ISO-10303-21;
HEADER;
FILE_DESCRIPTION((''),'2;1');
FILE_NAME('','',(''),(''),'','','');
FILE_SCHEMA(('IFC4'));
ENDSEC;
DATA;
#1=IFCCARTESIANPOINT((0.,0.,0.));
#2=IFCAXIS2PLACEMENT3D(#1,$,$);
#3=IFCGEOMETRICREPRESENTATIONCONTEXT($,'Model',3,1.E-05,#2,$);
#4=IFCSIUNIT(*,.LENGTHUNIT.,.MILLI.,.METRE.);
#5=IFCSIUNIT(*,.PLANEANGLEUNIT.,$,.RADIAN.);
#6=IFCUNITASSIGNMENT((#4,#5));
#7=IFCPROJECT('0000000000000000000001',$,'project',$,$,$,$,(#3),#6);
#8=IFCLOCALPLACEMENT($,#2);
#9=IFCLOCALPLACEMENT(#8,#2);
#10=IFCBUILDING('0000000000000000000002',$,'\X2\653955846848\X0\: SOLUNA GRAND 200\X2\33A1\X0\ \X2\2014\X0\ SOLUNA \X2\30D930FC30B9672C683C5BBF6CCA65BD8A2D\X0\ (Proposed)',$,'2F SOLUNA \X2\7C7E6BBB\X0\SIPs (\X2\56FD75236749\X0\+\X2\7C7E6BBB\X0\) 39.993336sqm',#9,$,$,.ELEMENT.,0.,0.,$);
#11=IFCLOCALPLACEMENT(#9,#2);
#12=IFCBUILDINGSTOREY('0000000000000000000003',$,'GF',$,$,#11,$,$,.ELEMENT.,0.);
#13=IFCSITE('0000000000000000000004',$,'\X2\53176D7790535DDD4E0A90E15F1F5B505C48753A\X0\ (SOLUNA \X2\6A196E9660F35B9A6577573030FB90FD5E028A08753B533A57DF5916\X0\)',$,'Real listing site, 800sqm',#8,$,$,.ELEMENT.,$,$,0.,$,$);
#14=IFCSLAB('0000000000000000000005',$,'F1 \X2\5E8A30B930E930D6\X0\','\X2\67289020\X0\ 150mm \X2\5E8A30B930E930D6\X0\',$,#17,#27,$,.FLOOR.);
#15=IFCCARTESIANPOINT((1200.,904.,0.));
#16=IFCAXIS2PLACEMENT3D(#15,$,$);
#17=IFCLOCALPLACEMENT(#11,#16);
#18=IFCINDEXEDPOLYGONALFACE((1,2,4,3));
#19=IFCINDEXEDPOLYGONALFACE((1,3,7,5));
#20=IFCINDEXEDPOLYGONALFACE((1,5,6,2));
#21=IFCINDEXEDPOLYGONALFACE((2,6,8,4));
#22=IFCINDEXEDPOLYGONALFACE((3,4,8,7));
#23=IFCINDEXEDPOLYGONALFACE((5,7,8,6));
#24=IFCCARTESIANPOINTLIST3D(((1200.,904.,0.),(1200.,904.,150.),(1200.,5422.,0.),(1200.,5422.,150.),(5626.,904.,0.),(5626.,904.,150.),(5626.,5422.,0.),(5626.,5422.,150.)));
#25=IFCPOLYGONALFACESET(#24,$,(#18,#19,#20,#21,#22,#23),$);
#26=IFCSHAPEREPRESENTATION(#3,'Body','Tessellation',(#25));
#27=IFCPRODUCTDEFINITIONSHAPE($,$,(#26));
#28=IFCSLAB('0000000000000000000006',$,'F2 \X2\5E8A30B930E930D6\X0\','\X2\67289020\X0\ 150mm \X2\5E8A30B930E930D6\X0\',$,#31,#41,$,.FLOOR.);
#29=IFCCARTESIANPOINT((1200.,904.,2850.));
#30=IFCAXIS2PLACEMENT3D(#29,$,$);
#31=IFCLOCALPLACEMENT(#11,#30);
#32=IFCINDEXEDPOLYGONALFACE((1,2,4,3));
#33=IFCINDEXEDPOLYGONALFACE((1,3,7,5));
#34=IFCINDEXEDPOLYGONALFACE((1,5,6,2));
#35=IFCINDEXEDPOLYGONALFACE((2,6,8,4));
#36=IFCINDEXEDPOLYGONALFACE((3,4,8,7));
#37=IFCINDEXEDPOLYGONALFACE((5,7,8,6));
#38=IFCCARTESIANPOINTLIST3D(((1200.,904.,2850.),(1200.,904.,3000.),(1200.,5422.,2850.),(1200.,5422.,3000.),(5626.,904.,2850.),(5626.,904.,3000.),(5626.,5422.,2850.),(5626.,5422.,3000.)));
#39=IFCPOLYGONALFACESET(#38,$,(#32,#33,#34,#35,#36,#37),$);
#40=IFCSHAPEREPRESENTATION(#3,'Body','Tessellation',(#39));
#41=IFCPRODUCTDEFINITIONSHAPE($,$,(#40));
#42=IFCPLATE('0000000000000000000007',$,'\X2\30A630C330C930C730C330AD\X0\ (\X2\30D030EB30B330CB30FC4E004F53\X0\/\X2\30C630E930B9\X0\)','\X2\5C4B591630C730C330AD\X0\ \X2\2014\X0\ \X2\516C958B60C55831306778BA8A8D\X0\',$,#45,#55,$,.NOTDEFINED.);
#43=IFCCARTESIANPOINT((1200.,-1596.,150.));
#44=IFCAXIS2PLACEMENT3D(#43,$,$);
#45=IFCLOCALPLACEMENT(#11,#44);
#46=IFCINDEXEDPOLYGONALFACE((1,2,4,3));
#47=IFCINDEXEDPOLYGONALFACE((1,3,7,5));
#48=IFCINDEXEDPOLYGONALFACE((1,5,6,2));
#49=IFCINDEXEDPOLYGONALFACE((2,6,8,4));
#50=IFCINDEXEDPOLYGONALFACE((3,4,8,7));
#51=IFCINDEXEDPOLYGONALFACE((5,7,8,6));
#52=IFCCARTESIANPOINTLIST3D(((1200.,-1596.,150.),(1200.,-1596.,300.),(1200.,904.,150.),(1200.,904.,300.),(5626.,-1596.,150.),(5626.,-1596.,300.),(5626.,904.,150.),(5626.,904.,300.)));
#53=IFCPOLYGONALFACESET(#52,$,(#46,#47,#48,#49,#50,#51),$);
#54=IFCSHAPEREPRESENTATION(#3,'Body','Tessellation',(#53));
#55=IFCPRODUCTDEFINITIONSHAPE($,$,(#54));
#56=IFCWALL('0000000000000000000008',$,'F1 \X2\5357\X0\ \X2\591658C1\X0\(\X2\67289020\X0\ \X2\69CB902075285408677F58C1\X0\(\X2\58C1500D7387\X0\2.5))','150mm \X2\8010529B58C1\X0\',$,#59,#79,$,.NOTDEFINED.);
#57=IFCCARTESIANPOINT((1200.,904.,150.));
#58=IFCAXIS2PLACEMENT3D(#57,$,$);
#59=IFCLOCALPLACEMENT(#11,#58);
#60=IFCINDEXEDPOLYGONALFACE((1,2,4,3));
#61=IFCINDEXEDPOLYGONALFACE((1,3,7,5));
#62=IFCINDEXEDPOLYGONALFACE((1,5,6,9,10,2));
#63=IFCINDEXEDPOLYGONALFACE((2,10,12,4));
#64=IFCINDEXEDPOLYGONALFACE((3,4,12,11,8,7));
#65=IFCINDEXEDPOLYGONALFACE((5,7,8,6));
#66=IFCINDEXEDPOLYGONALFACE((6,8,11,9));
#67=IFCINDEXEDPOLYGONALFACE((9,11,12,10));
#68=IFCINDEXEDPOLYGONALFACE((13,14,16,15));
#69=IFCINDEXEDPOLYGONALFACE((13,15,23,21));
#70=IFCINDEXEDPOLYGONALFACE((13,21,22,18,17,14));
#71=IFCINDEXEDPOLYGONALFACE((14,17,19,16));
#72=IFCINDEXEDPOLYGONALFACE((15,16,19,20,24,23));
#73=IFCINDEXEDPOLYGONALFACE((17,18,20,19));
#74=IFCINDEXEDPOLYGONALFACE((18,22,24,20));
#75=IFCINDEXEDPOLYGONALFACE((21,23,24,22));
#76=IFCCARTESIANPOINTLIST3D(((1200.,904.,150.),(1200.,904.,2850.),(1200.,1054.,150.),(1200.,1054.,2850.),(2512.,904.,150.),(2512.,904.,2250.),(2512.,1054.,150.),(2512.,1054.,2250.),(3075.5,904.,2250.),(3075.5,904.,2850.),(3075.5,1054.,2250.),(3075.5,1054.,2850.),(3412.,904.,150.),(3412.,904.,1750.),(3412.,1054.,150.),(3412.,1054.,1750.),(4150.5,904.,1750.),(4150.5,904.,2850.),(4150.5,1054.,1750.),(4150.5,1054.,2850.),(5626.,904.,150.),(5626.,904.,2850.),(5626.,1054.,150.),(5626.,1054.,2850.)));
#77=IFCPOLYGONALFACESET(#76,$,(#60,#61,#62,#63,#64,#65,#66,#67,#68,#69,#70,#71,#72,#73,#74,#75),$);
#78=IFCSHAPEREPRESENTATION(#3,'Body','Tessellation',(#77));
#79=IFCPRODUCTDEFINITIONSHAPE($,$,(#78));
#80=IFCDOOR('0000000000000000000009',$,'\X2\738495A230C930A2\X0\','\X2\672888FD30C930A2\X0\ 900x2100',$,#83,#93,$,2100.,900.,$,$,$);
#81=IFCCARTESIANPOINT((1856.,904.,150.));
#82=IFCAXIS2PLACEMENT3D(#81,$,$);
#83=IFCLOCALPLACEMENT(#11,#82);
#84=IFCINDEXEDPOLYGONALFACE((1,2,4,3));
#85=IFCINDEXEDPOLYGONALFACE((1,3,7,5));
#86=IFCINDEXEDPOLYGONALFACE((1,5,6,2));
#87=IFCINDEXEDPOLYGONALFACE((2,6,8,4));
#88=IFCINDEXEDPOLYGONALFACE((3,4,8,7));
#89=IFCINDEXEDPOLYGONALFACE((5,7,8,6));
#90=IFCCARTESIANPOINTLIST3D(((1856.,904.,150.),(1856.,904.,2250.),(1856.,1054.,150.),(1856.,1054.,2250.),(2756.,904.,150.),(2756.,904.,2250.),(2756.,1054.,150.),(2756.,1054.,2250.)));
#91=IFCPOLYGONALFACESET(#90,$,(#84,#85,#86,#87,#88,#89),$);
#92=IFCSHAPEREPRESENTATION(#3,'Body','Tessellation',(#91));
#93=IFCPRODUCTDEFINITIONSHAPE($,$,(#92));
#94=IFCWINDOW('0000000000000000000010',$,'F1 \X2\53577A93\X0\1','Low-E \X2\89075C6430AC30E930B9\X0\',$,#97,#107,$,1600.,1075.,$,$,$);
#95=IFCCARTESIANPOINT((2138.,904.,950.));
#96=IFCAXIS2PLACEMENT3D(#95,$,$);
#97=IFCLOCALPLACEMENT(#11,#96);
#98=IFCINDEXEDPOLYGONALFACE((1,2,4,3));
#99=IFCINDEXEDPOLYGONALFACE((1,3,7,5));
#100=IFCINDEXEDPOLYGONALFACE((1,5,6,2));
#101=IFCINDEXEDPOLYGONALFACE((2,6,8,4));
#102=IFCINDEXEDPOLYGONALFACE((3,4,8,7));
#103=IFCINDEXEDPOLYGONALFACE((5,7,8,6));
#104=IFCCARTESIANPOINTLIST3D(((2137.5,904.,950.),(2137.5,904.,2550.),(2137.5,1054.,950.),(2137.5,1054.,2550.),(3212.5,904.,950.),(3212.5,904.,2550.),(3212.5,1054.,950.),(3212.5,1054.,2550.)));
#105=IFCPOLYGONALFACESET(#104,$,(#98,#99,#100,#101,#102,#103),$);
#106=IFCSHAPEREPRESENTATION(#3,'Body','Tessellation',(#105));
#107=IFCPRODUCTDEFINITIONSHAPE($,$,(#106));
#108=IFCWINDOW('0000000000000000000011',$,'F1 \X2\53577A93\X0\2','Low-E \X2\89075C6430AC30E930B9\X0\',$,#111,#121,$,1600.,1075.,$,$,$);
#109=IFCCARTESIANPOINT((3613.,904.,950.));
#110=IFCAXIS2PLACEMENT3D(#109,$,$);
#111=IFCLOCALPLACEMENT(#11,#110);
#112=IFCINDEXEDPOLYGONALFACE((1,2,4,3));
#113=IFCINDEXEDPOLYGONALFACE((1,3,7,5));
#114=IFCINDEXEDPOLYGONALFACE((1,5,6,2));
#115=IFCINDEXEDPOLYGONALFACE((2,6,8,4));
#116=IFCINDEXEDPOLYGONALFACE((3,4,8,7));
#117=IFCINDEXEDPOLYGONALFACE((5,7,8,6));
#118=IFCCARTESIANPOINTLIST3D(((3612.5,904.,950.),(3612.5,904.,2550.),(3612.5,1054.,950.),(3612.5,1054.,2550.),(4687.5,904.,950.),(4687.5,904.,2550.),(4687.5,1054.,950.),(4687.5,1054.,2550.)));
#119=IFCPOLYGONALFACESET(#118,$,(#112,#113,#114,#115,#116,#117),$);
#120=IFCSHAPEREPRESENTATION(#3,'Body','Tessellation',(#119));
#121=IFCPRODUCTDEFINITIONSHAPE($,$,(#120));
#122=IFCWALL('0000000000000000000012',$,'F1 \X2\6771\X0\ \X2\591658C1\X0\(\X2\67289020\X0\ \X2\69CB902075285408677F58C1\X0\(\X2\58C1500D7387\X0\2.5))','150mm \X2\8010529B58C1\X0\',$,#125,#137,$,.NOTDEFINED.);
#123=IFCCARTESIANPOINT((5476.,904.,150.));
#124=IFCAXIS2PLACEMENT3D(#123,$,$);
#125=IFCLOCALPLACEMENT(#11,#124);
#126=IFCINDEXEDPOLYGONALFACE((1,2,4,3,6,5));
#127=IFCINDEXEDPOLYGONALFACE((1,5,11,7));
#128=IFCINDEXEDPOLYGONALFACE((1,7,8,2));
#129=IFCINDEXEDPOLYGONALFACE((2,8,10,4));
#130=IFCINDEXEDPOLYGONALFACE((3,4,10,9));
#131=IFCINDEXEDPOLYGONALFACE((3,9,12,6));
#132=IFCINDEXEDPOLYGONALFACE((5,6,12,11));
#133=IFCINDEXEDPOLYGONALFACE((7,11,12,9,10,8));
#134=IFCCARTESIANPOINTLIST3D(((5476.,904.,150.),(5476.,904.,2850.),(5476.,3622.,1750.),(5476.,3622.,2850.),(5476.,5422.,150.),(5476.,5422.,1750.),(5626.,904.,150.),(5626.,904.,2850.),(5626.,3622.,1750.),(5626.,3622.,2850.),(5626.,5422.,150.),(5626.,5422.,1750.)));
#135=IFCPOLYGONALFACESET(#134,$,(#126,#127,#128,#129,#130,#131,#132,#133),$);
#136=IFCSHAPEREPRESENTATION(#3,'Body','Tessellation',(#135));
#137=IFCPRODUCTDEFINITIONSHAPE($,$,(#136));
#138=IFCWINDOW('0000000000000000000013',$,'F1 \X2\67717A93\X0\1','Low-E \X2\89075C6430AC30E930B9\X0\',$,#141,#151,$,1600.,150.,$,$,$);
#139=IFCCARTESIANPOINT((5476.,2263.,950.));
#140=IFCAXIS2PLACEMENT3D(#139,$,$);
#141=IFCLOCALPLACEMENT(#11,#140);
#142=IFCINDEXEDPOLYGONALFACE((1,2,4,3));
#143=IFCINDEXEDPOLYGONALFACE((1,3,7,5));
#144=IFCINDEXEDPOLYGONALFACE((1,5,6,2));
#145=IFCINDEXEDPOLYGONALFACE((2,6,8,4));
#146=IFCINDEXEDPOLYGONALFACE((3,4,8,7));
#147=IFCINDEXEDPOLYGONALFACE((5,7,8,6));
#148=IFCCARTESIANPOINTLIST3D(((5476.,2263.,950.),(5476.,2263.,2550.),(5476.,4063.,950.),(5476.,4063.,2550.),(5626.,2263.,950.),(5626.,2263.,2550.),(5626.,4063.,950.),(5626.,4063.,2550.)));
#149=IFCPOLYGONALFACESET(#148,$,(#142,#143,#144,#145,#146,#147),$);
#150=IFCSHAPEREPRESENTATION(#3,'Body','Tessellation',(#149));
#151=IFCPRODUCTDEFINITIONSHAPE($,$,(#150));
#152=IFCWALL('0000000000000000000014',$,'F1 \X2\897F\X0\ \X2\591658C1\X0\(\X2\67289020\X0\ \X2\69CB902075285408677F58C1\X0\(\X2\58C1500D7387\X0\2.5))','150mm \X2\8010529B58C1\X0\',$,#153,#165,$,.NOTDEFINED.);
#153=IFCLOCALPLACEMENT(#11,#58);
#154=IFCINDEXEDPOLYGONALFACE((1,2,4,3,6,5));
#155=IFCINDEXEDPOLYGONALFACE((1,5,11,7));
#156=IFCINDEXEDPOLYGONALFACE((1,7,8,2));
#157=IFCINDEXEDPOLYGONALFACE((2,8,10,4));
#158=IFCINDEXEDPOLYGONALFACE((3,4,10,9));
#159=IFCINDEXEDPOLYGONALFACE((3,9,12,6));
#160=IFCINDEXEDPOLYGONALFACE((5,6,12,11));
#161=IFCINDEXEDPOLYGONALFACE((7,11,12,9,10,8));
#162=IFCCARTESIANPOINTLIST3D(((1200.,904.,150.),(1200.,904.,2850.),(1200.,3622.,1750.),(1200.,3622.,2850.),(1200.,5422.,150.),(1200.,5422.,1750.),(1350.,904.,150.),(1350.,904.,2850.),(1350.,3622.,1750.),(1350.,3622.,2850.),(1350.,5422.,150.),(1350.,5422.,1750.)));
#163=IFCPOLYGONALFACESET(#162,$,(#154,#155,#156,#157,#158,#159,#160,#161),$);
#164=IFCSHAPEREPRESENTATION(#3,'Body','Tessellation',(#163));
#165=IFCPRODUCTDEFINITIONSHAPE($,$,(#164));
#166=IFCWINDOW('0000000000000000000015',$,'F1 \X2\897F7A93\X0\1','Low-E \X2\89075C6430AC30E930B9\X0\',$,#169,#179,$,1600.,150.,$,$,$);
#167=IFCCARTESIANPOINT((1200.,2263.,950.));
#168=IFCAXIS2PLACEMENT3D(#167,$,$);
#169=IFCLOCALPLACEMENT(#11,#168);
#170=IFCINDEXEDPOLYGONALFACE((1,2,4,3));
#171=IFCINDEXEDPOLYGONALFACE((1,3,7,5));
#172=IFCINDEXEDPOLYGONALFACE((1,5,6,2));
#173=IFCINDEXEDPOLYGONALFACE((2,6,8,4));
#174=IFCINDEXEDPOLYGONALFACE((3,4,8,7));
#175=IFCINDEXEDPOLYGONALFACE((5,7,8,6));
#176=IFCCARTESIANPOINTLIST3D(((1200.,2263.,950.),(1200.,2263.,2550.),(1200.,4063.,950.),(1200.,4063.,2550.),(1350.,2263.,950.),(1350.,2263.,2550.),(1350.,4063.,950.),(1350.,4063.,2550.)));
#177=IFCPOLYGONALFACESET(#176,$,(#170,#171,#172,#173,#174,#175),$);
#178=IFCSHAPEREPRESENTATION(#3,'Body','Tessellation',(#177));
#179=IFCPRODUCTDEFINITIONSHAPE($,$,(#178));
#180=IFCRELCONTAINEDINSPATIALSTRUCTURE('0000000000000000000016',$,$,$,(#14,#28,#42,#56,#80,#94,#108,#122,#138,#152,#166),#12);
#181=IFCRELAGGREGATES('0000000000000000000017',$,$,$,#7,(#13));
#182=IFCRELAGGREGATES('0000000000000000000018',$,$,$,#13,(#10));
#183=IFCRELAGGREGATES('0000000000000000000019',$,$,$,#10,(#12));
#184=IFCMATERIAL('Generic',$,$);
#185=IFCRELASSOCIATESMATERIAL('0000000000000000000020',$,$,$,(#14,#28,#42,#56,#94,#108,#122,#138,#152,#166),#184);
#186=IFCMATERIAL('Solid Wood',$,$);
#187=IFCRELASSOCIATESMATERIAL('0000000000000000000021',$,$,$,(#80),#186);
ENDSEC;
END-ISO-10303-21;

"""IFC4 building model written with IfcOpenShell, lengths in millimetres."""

from ifc_helpers import new_model, si_unit, frame, frame_2d, origin, place, context, project, spatial, rectangle, extrude, material, element, fill, save


model = new_model("IFC4")

# Units and contexts
model_context = context("Model", 3, precision=1e-05, world=origin())
ifc_project = project(units=[si_unit("LENGTHUNIT", "METRE", prefix="MILLI"), si_unit("PLANEANGLEUNIT", "RADIAN")], contexts=[model_context])

# Site, building, storey
site_placement = place(None, origin())
site = spatial("IfcSite", under=ifc_project, at=site_placement, Name="北海道川上郡弟子屈町 (SOLUNA 標準想定敷地・都市計画区域外)", ObjectType="Real listing site, 800sqm", CompositionType="ELEMENT", RefElevation=0.0)
building_placement = place(site_placement, origin())
building = spatial("IfcBuilding", under=site, at=building_placement, Name="改善案: SOLUNA GRAND 200㎡ — SOLUNA ベース本格宿泊施設 (Proposed)", ObjectType="2F SOLUNA 籾殻SIPs (国産杉+籾殻) 39.993336sqm", CompositionType="ELEMENT", ElevationOfRefHeight=0.0, ElevationOfTerrain=0.0)
storey_placement = place(building_placement, origin())
storey = spatial("IfcBuildingStorey", under=building, at=storey_placement, Name="GF", CompositionType="ELEMENT", Elevation=0.0)

# Slabs
ifc_material_1 = material(Name="Generic")
slab_1_placement = place(storey_placement, frame((1200.0, 904.0, 0.0)))
element("IfcSlab", 1, at=slab_1_placement, inside=storey, material=ifc_material_1, Name="F1 床スラブ", Description="木造 150mm 床スラブ", PredefinedType="FLOOR", context=model_context, shape_type="SweptSolid", body=[
    extrude(rectangle(XDim=4426.0, YDim=4518.0, at=frame_2d((2213.0, 2259.0))), frame((1200.0, 904.0, 0.0)), (0.0, 0.0, 1.0), 150.0),
])
slab_2_placement = place(storey_placement, frame((1200.0, 904.0, 2850.0)))
element("IfcSlab", 2, at=slab_2_placement, inside=storey, material=ifc_material_1, Name="F2 床スラブ", Description="木造 150mm 床スラブ", PredefinedType="FLOOR", context=model_context, shape_type="SweptSolid", body=[
    extrude(rectangle(XDim=4426.0, YDim=4518.0, at=frame_2d((2213.0, 2259.0))), frame((1200.0, 904.0, 2850.0)), (0.0, 0.0, 1.0), 150.0),
])

# Plate
plate_placement = place(storey_placement, frame((1200.0, -1596.0, 150.0)))
element("IfcPlate", 3, at=plate_placement, inside=storey, material=ifc_material_1, Name="ウッドデッキ (バルコニー一体/テラス)", Description="屋外デッキ — 公開情報で確認", PredefinedType="NOTDEFINED", context=model_context, shape_type="SweptSolid", body=[
    extrude(rectangle(XDim=4426.0, YDim=2500.0, at=frame_2d((2213.0, 1250.0))), frame((1200.0, -1596.0, 150.0)), (0.0, 0.0, 1.0), 150.0),
])

# Wall, openings, door, windows
wall_1_placement = place(storey_placement, frame((1200.0, 904.0, 150.0)))
wall_1 = element("IfcWall", 4, at=wall_1_placement, inside=storey, material=ifc_material_1, Name="F1 南 外壁(木造 構造用合板壁(壁倍率2.5))", Description="150mm 耐力壁", PredefinedType="NOTDEFINED", context=model_context, shape_type="SweptSolid", body=[
    extrude(rectangle(XDim=4426.0, YDim=150.0, at=frame_2d((2213.0, 75.0))), frame((1200.0, 904.0, 150.0)), (0.0, 0.0, 1.0), 2700.0),
])
opening_1_placement = place(storey_placement, frame((1856.0, 904.0, 150.0)))
opening_1 = element("IfcOpeningElement", 5, at=opening_1_placement, cuts=wall_1, PredefinedType="NOTDEFINED", context=model_context, shape_type="SweptSolid", body=[
    extrude(rectangle(XDim=900.0, YDim=150.0, at=frame_2d((450.0, 75.0))), frame((1856.0, 904.0, 150.0)), (0.0, 0.0, 1.0), 2100.0),
])
opening_2_placement = place(storey_placement, frame((2138.0, 904.0, 950.0)))
opening_2 = element("IfcOpeningElement", 6, at=opening_2_placement, cuts=wall_1, PredefinedType="NOTDEFINED", context=model_context, shape_type="SweptSolid", body=[
    extrude(rectangle(XDim=1075.0, YDim=150.0, at=frame_2d((537.0, 75.0))), frame((2138.0, 904.0, 950.0)), (0.0, 0.0, 1.0), 1600.0),
])
opening_3_placement = place(storey_placement, frame((3613.0, 904.0, 950.0)))
opening_3 = element("IfcOpeningElement", 7, at=opening_3_placement, cuts=wall_1, PredefinedType="NOTDEFINED", context=model_context, shape_type="SweptSolid", body=[
    extrude(rectangle(XDim=1075.0, YDim=150.0, at=frame_2d((537.0, 75.0))), frame((3613.0, 904.0, 950.0)), (0.0, 0.0, 1.0), 1600.0),
])
ifc_material_2 = material(Name="Solid Wood")
door_placement = place(storey_placement, frame((1856.0, 904.0, 150.0)))
door = element("IfcDoor", 8, at=door_placement, inside=storey, material=ifc_material_2, Name="玄関ドア", Description="木製ドア 900x2100", OverallHeight=2100.0, OverallWidth=900.0, context=model_context, shape_type="SweptSolid", body=[
    extrude(rectangle(XDim=900.0, YDim=150.0, at=frame_2d((450.0, 75.0))), frame((1856.0, 904.0, 150.0)), (0.0, 0.0, 1.0), 2100.0),
])
fill(opening_1, door)
window_1_placement = place(storey_placement, frame((2138.0, 904.0, 950.0)))
window_1 = element("IfcWindow", 9, at=window_1_placement, inside=storey, material=ifc_material_1, Name="F1 南窓1", Description="Low-E 複層ガラス", OverallHeight=1600.0, OverallWidth=1075.0, context=model_context, shape_type="SweptSolid", body=[
    extrude(rectangle(XDim=1075.0, YDim=150.0, at=frame_2d((537.0, 75.0))), frame((2138.0, 904.0, 950.0)), (0.0, 0.0, 1.0), 1600.0),
])
fill(opening_2, window_1)
window_2_placement = place(storey_placement, frame((3613.0, 904.0, 950.0)))
window_2 = element("IfcWindow", 10, at=window_2_placement, inside=storey, material=ifc_material_1, Name="F1 南窓2", Description="Low-E 複層ガラス", OverallHeight=1600.0, OverallWidth=1075.0, context=model_context, shape_type="SweptSolid", body=[
    extrude(rectangle(XDim=1075.0, YDim=150.0, at=frame_2d((537.0, 75.0))), frame((3613.0, 904.0, 950.0)), (0.0, 0.0, 1.0), 1600.0),
])
fill(opening_3, window_2)

# Walls, openings, windows
wall_2_placement = place(storey_placement, frame((5476.0, 904.0, 150.0)))
wall_2 = element("IfcWall", 11, at=wall_2_placement, inside=storey, material=ifc_material_1, Name="F1 東 外壁(木造 構造用合板壁(壁倍率2.5))", Description="150mm 耐力壁", PredefinedType="NOTDEFINED", context=model_context, shape_type="SweptSolid", body=[
    extrude(rectangle(XDim=150.0, YDim=4518.0, at=frame_2d((75.0, 2259.0))), frame((5476.0, 904.0, 150.0)), (0.0, 0.0, 1.0), 2700.0),
])
opening_4_placement = place(storey_placement, frame((5476.0, 2263.0, 950.0)))
opening_4 = element("IfcOpeningElement", 12, at=opening_4_placement, cuts=wall_2, PredefinedType="NOTDEFINED", context=model_context, shape_type="SweptSolid", body=[
    extrude(rectangle(XDim=150.0, YDim=1800.0, at=frame_2d((75.0, 900.0))), frame((5476.0, 2263.0, 950.0)), (0.0, 0.0, 1.0), 1600.0),
])
window_3_placement = place(storey_placement, frame((5476.0, 2263.0, 950.0)))
window_3 = element("IfcWindow", 13, at=window_3_placement, inside=storey, material=ifc_material_1, Name="F1 東窓1", Description="Low-E 複層ガラス", OverallHeight=1600.0, OverallWidth=150.0, context=model_context, shape_type="SweptSolid", body=[
    extrude(rectangle(XDim=150.0, YDim=1800.0, at=frame_2d((75.0, 900.0))), frame((5476.0, 2263.0, 950.0)), (0.0, 0.0, 1.0), 1600.0),
])
fill(opening_4, window_3)
wall_3_placement = place(storey_placement, frame((1200.0, 904.0, 150.0)))
wall_3 = element("IfcWall", 14, at=wall_3_placement, inside=storey, material=ifc_material_1, Name="F1 西 外壁(木造 構造用合板壁(壁倍率2.5))", Description="150mm 耐力壁", PredefinedType="NOTDEFINED", context=model_context, shape_type="SweptSolid", body=[
    extrude(rectangle(XDim=150.0, YDim=4518.0, at=frame_2d((75.0, 2259.0))), frame((1200.0, 904.0, 150.0)), (0.0, 0.0, 1.0), 2700.0),
])
opening_5_placement = place(storey_placement, frame((1200.0, 2263.0, 950.0)))
opening_5 = element("IfcOpeningElement", 15, at=opening_5_placement, cuts=wall_3, PredefinedType="NOTDEFINED", context=model_context, shape_type="SweptSolid", body=[
    extrude(rectangle(XDim=150.0, YDim=1800.0, at=frame_2d((75.0, 900.0))), frame((1200.0, 2263.0, 950.0)), (0.0, 0.0, 1.0), 1600.0),
])
window_4_placement = place(storey_placement, frame((1200.0, 2263.0, 950.0)))
window_4 = element("IfcWindow", 16, at=window_4_placement, inside=storey, material=ifc_material_1, Name="F1 西窓1", Description="Low-E 複層ガラス", OverallHeight=1600.0, OverallWidth=150.0, context=model_context, shape_type="SweptSolid", body=[
    extrude(rectangle(XDim=150.0, YDim=1800.0, at=frame_2d((75.0, 900.0))), frame((1200.0, 2263.0, 950.0)), (0.0, 0.0, 1.0), 1600.0),
])
fill(opening_5, window_4)

save(model, "model.ifc")
